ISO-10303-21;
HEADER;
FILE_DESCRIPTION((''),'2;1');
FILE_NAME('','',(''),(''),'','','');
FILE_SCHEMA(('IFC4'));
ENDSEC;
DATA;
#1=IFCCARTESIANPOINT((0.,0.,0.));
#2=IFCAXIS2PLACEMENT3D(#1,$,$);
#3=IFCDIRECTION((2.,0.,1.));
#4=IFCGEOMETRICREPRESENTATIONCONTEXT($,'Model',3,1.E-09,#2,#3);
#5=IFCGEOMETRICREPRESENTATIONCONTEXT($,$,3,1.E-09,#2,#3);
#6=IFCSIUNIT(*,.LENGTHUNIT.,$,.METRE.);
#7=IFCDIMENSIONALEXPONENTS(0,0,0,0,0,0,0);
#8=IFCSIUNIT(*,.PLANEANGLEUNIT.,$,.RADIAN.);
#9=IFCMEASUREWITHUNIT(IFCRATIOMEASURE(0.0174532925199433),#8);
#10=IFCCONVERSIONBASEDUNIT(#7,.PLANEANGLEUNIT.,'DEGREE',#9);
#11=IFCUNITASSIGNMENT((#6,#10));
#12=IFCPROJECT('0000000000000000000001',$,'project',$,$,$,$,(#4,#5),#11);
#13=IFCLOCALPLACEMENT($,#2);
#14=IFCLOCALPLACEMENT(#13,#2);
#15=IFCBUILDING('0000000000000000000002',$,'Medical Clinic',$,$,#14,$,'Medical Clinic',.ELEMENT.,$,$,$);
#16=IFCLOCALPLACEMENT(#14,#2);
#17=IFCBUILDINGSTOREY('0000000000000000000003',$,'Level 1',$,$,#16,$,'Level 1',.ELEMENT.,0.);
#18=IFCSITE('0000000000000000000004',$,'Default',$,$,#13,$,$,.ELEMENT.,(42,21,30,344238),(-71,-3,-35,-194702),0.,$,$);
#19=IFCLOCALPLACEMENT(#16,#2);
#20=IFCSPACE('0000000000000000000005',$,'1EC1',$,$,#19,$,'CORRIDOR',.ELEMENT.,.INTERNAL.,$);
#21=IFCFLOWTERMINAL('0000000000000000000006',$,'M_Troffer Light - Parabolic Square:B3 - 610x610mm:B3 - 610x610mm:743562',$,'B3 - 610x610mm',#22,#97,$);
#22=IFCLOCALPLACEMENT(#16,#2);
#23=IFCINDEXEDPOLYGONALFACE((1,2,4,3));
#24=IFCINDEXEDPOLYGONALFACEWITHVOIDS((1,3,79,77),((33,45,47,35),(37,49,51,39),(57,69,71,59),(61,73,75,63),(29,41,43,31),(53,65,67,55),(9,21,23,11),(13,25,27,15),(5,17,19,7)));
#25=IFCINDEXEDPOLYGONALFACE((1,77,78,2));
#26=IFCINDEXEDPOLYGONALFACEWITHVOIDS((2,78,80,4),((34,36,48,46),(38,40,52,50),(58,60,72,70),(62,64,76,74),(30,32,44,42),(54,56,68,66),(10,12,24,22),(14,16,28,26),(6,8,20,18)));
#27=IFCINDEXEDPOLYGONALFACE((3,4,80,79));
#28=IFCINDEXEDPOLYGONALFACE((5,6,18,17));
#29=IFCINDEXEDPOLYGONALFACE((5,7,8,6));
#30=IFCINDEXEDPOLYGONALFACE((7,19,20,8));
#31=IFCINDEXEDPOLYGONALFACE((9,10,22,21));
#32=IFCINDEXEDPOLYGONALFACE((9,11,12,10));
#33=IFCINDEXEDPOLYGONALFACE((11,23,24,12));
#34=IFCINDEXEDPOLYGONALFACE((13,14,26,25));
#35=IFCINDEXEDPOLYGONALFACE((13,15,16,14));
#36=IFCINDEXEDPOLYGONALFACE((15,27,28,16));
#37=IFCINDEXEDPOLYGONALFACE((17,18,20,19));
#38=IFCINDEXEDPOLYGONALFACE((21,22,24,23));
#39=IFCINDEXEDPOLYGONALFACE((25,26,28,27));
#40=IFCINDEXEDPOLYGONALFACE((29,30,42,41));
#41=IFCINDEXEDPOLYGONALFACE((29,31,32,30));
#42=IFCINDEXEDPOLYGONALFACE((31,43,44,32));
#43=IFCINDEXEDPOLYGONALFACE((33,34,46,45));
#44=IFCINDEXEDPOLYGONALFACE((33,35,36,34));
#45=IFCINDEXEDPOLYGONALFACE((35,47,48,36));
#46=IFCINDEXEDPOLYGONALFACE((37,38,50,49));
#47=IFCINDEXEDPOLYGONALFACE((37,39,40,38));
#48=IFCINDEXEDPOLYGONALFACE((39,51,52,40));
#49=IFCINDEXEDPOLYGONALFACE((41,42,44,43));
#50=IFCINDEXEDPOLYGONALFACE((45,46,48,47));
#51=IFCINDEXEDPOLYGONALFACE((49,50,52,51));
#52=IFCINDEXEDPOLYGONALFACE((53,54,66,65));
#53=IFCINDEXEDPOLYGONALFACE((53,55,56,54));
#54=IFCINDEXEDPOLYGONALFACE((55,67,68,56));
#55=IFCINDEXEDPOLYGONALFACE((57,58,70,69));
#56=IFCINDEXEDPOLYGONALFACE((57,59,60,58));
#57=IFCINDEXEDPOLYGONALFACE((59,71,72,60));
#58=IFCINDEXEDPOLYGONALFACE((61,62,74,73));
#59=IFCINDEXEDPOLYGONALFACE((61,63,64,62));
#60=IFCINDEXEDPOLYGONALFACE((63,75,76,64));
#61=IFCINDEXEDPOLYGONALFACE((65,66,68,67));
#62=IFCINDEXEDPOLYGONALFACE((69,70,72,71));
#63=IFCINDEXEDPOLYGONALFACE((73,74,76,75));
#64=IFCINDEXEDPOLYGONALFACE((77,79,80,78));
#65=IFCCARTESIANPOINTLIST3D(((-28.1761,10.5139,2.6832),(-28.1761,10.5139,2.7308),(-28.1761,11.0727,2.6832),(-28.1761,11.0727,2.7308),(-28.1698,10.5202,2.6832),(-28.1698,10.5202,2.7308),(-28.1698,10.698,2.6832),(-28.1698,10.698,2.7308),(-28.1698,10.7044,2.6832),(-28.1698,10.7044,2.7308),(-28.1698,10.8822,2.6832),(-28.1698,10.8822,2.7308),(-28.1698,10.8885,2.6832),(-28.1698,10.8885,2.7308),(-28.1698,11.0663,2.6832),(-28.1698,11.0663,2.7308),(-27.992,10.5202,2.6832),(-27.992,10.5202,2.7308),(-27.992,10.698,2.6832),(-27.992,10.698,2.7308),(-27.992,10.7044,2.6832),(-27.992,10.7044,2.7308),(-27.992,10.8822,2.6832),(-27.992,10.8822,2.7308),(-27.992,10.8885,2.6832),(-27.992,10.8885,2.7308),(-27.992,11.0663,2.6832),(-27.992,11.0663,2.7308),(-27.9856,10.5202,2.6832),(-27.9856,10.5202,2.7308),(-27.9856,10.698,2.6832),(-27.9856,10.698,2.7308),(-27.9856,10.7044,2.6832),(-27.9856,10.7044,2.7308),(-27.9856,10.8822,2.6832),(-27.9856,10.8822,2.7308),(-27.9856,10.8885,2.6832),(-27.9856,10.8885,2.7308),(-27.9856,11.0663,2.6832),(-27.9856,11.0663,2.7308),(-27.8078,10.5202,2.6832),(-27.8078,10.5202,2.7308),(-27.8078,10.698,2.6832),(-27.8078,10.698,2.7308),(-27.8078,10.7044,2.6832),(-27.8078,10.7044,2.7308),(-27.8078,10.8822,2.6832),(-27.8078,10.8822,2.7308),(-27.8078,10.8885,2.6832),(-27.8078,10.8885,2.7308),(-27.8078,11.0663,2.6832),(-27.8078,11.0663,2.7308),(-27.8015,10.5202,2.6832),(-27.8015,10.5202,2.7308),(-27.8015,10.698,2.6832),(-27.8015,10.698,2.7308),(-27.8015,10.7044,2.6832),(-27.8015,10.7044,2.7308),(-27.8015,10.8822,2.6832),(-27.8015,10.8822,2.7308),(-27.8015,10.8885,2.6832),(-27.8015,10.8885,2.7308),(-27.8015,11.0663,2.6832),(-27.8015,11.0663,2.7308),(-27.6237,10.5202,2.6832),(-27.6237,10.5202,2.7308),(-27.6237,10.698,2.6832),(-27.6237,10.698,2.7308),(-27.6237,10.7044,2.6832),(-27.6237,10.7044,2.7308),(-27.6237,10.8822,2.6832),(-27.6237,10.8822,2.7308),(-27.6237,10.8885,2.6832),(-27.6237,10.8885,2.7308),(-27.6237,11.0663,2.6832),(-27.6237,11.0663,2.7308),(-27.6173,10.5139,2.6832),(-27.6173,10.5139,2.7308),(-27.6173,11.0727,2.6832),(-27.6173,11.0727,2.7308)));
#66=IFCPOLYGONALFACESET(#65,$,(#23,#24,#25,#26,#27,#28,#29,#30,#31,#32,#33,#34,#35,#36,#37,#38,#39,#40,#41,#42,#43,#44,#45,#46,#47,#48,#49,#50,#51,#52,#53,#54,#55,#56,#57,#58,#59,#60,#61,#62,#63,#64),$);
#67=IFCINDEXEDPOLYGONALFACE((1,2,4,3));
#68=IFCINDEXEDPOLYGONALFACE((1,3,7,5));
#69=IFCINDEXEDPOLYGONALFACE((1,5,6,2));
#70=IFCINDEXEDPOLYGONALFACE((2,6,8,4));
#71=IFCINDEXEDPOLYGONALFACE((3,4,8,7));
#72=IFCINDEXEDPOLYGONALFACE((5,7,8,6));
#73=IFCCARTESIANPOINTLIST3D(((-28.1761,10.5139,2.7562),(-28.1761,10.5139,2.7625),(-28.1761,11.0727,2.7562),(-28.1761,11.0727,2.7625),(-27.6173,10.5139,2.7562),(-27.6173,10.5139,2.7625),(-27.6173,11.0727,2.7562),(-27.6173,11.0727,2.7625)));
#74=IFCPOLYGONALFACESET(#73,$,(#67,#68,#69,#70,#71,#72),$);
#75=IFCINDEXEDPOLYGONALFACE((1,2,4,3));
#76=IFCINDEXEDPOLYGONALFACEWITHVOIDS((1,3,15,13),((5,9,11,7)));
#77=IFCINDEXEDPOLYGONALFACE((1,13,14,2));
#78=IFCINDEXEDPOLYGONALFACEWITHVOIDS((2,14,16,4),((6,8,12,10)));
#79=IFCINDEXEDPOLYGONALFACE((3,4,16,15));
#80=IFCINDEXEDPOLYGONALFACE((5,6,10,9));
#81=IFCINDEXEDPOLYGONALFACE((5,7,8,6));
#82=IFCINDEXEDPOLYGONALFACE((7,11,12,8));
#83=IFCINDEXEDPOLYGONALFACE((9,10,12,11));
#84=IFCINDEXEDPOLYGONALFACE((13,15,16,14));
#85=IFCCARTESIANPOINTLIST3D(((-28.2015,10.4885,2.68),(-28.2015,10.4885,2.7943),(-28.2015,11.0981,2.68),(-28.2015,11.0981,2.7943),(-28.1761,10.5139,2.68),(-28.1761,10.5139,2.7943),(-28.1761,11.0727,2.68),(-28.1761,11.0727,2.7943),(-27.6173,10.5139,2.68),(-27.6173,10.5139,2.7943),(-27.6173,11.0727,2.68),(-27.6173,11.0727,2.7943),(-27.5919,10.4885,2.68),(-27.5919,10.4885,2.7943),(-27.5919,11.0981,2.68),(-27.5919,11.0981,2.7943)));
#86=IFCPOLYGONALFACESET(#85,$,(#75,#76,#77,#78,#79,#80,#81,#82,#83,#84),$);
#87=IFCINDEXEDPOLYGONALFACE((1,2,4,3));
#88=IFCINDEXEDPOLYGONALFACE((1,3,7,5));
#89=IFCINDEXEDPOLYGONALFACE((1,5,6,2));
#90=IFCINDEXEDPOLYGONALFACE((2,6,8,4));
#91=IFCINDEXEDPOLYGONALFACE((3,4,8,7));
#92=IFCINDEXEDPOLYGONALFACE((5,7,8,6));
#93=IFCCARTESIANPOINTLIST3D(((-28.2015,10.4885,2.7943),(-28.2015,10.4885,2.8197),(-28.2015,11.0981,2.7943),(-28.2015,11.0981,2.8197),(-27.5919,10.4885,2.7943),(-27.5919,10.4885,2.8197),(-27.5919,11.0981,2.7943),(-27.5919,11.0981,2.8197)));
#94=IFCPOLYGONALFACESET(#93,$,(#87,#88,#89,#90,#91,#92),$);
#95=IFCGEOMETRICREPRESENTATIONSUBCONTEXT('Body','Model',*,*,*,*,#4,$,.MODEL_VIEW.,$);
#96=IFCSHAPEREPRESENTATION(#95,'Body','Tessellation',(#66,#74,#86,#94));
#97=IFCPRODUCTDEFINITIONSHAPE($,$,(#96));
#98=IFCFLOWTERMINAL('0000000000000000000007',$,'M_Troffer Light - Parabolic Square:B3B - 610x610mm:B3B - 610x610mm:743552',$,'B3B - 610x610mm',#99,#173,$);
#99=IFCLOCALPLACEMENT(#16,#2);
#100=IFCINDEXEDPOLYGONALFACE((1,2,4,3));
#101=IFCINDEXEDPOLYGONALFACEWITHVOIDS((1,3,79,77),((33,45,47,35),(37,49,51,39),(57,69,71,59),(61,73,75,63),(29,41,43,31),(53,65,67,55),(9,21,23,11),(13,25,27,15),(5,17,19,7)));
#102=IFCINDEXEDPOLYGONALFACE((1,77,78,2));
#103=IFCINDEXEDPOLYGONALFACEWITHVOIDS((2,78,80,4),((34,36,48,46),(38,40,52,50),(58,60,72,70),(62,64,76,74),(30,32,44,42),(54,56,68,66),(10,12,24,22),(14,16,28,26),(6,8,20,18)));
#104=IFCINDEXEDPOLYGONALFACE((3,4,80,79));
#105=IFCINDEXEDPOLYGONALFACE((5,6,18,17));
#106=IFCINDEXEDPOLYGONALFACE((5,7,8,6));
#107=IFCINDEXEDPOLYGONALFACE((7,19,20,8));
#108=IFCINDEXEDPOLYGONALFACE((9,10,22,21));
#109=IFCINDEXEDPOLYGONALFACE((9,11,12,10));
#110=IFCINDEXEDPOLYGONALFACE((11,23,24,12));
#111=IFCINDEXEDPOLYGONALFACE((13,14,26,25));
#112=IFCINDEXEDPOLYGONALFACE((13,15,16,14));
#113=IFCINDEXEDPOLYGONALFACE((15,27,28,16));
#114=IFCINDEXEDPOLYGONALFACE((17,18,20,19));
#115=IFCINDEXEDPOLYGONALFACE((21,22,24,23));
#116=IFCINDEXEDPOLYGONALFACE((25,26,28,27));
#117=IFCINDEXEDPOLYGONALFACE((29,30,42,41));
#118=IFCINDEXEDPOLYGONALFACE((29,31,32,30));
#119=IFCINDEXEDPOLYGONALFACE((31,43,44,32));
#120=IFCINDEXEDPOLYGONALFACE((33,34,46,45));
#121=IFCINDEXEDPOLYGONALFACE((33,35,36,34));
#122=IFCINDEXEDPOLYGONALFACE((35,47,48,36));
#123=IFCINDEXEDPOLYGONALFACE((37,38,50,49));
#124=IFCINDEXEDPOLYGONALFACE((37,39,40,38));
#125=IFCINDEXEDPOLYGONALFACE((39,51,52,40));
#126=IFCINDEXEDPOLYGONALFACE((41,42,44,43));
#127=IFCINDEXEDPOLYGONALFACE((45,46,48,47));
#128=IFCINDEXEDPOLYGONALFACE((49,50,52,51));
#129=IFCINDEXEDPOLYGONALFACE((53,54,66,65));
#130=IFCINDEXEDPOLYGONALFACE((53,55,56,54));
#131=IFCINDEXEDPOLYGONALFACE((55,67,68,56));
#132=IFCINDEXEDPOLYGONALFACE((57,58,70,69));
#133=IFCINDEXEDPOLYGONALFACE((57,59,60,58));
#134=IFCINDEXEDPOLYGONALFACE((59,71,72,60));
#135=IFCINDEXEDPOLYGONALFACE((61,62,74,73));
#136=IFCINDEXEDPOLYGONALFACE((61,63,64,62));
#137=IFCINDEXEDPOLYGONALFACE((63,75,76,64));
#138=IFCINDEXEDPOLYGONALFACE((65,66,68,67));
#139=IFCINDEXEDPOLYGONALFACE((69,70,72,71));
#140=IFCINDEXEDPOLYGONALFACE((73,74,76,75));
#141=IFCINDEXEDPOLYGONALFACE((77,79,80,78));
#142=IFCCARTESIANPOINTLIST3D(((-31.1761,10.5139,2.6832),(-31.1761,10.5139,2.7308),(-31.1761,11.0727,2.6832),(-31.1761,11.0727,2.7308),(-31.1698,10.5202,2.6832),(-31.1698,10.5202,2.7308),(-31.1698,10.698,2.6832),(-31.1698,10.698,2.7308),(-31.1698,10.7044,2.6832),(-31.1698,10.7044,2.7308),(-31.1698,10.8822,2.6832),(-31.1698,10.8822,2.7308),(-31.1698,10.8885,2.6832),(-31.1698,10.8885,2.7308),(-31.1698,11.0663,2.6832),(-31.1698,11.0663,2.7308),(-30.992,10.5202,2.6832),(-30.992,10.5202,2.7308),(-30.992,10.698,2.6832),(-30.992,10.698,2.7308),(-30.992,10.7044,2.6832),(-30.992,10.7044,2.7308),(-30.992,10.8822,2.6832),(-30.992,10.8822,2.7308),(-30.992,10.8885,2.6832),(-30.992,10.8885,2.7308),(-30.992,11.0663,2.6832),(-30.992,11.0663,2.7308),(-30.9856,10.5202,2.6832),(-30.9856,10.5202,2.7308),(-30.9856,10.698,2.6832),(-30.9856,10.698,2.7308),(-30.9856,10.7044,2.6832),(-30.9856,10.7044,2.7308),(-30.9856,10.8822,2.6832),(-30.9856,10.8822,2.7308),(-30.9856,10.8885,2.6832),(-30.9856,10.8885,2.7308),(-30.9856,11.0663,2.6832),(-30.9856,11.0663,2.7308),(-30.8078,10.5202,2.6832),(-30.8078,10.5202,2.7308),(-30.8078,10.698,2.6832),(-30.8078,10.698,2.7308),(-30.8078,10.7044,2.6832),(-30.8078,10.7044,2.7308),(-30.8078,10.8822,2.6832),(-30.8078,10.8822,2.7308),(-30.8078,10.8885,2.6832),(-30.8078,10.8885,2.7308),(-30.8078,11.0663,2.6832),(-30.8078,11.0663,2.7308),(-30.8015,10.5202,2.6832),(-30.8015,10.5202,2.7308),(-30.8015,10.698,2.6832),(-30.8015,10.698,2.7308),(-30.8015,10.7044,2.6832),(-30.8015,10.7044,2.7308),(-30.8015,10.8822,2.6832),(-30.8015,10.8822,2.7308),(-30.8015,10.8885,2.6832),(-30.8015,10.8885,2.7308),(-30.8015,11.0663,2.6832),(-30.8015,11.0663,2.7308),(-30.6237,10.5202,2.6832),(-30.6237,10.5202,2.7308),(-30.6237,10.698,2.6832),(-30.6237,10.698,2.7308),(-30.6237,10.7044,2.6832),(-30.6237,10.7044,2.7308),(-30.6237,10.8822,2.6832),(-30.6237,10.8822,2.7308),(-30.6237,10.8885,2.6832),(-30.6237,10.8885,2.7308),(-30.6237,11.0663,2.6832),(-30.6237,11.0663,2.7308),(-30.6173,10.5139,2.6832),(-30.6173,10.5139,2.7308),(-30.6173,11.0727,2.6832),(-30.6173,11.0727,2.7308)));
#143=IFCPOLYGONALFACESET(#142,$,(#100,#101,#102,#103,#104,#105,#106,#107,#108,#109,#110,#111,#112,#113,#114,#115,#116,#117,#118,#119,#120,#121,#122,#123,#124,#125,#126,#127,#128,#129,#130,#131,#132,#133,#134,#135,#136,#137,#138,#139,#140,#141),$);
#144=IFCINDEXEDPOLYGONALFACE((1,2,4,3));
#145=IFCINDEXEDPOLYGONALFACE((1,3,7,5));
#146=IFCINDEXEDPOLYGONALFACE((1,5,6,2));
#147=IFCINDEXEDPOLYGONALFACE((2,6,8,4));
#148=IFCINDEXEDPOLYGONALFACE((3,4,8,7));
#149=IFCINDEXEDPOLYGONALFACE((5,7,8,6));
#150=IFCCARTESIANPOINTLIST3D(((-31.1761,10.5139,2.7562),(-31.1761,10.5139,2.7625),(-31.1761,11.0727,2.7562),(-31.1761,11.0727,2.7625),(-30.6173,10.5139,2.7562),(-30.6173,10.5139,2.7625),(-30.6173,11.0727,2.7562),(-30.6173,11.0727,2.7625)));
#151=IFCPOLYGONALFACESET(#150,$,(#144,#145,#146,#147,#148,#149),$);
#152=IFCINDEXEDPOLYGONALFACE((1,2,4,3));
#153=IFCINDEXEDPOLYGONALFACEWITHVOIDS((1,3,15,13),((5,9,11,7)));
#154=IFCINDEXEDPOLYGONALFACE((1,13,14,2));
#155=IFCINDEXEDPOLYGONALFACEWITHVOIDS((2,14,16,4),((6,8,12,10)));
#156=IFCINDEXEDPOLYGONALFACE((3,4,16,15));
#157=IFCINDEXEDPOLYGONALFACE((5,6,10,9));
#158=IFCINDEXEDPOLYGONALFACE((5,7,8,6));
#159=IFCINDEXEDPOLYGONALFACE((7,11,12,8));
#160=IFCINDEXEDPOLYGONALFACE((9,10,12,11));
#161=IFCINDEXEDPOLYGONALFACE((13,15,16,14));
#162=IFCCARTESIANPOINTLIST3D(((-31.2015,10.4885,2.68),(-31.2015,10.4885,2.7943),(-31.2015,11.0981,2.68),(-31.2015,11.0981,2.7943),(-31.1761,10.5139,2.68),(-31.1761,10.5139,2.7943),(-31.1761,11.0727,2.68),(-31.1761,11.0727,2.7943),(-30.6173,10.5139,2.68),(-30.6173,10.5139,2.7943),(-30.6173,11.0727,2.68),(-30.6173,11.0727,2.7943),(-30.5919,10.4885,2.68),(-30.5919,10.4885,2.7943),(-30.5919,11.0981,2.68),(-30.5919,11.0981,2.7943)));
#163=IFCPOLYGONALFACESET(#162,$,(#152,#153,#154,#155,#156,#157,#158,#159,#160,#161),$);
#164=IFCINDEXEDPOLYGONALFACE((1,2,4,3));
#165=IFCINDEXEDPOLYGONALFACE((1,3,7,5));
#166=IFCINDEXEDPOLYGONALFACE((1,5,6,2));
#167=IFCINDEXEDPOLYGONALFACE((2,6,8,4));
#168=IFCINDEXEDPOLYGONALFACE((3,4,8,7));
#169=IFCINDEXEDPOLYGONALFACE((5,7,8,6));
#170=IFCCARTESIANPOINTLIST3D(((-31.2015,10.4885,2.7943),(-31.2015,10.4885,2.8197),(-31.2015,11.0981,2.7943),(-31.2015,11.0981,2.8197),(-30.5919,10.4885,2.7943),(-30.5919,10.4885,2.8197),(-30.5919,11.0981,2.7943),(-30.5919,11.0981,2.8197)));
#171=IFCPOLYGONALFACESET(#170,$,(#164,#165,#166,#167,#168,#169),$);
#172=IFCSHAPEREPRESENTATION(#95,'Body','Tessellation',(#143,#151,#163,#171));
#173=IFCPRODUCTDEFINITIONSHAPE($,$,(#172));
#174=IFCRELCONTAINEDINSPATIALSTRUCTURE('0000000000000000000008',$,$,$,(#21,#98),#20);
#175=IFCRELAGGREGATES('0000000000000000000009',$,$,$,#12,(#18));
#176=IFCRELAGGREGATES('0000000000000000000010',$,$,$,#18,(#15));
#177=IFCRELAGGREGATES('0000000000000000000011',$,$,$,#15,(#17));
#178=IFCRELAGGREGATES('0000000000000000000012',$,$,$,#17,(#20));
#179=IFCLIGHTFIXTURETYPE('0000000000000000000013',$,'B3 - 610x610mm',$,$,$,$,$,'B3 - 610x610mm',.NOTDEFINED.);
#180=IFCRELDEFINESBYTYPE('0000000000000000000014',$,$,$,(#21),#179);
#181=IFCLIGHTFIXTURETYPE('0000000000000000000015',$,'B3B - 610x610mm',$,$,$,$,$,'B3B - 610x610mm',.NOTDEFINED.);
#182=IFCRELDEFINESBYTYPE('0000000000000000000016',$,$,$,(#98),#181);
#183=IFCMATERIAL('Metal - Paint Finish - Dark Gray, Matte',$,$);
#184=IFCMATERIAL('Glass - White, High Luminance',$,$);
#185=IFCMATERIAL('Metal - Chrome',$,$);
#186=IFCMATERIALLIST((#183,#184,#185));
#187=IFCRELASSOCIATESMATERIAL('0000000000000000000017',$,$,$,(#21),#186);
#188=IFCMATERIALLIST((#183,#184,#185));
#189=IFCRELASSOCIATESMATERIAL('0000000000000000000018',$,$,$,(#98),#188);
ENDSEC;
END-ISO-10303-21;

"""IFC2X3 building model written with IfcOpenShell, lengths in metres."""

from ifc_helpers import new_model, entity, si_unit, converted_unit, direction, frame, origin, origin_2d_with_axis, place, context, subcontext, project, spatial, polyline, rectangle, outline, extrude, source, transform, mapped, material, material_list, type_object, type_shapes, element, save


model = new_model("IFC2X3")

# Units and contexts
model_context = context("Model", 3, precision=1e-09, world=origin(), true_north=direction((2.0, 0.0, 1.0)))
context_of_model = context(None, 3, precision=1e-09, world=origin(), true_north=direction((2.0, 0.0, 1.0)))
body_context = subcontext(model_context, "Body", "Model", "MODEL_VIEW")
ifc_project = project(units=[si_unit("LENGTHUNIT", "METRE"), converted_unit("PLANEANGLEUNIT", "DEGREE", entity("IfcRatioMeasure", 0.0174532925199433), si_unit("PLANEANGLEUNIT", "RADIAN"), dimensions=[0, 0, 0, 0, 0, 0, 0])], contexts=[model_context, context_of_model])

# Site, building, storey
site_placement = place(None, origin())
site = spatial("IfcSite", under=ifc_project, at=site_placement, Name="Default", CompositionType="ELEMENT", RefLatitude=(42, 21, 30, 344238), RefLongitude=(-71, -3, -35, -194702), RefElevation=0.0)
building_placement = place(site_placement, origin())
building = spatial("IfcBuilding", under=site, at=building_placement, Name="Medical Clinic", LongName="Medical Clinic", CompositionType="ELEMENT")
storey_placement = place(building_placement, origin())
storey = spatial("IfcBuildingStorey", under=building, at=storey_placement, Name="Level 1", LongName="Level 1", CompositionType="ELEMENT", Elevation=0.0)

# Shared definitions
ifc_material_1 = material(Name="Metal - Paint Finish - Dark Gray, Matte")
ifc_material_2 = material(Name="Glass - White, High Luminance")
ifc_material_3 = material(Name="Metal - Chrome")
light_fixture_type_1 = type_object("IfcLightFixtureType", Name="B3 - 610x610mm", ElementType="B3 - 610x610mm", PredefinedType="NOTDEFINED")
shared_shape_1 = source(origin(), body_context, "Body", "SweptSolid", [
    extrude(outline(polyline([(-0.2794, -0.2794), (0.2794, -0.2794), (0.2794, 0.2794), (-0.2794, 0.2794), (-0.2794, -0.2794)]), holes=[polyline([(-0.0952, 0.0953), (-0.273, 0.0953), (-0.273, 0.2731), (-0.0952, 0.2731), (-0.0952, 0.0953)]), polyline([(0.2731, 0.0953), (0.0953, 0.0953), (0.0953, 0.2731), (0.2731, 0.2731), (0.2731, 0.0953)]), polyline([(-0.0889, 0.2731), (0.0889, 0.2731), (0.0889, 0.0953), (-0.0889, 0.0953), (-0.0889, 0.2731)]), polyline([(0.2731, -0.273), (0.0953, -0.273), (0.0953, -0.0952), (0.2731, -0.0952), (0.2731, -0.273)]), polyline([(0.0889, -0.273), (-0.0889, -0.273), (-0.0889, -0.0952), (0.0889, -0.0952), (0.0889, -0.273)]), polyline([(-0.0952, -0.273), (-0.273, -0.273), (-0.273, -0.0952), (-0.0952, -0.0952), (-0.0952, -0.273)]), polyline([(-0.0952, -0.0889), (-0.273, -0.0889), (-0.273, 0.0889), (-0.0952, 0.0889), (-0.0952, -0.0889)]), polyline([(0.0889, -0.0889), (-0.0889, -0.0889), (-0.0889, 0.0889), (0.0889, 0.0889), (0.0889, -0.0889)]), polyline([(0.2731, -0.0889), (0.0953, -0.0889), (0.0953, 0.0889), (0.2731, 0.0889), (0.2731, -0.0889)])]), frame((0.0, -0.3048, -0.0508), z_axis=(0.0, 0.0, 1.0), x_axis=(-1.0, 0.0, 0.0)), (0.0, 0.0, 1.0), 0.0476),
    extrude(rectangle(XDim=0.5588, YDim=0.5588, at=origin_2d_with_axis()), frame((0.0, -0.3048, -0.0825), z_axis=(0.0, 0.0, 1.0), x_axis=(-1.0, 0.0, 0.0)), (0.0, 0.0, 1.0), 0.0064),
    extrude(outline(polyline([(-0.3048, -0.3048), (0.3048, -0.3048), (0.3048, 0.3048), (-0.3048, 0.3048), (-0.3048, -0.3048)]), holes=[polyline([(0.2794, 0.2794), (0.2794, -0.2794), (-0.2794, -0.2794), (-0.2794, 0.2794), (0.2794, 0.2794)])]), frame((0.0, -0.3048, -0.1143)), (0.0, 0.0, 1.0), 0.1143),
    extrude(rectangle(XDim=0.6096, YDim=0.6096, at=origin_2d_with_axis()), frame((0.0, -0.3048, -0.1397), z_axis=(0.0, 0.0, 1.0), x_axis=(-1.0, 0.0, 0.0)), (0.0, 0.0, 1.0), 0.0254),
])
type_shapes(light_fixture_type_1, [shared_shape_1])

# Shared definitions
space_1_placement = place(storey_placement, origin())
space_1 = spatial("IfcSpace", under=storey, at=space_1_placement, Name="1EC1", LongName="CORRIDOR", CompositionType="ELEMENT", InteriorOrExteriorSpace="INTERNAL")

# Flow terminals
ifc_material_list_1 = material_list([ifc_material_1, ifc_material_2, ifc_material_3])
flow_terminal_1_placement = place(space_1_placement, frame((-27.8967, 10.4885, 2.68), z_axis=(0.0, 0.0, -1.0), x_axis=(1.0, 0.0, 0.0)))
element("IfcFlowTerminal", 1, at=flow_terminal_1_placement, inside=space_1, type_object=light_fixture_type_1, material=ifc_material_list_1, Name="M_Troffer Light - Parabolic Square:B3 - 610x610mm:B3 - 610x610mm:743562", ObjectType="B3 - 610x610mm", context=body_context, shape_type="MappedRepresentation", body=[
    mapped(shared_shape_1, transform((0.0, 0.0, 0.0), scale=1.0)),
])
ifc_material_list_2 = material_list([ifc_material_1, ifc_material_2, ifc_material_3])
light_fixture_type_2 = type_object("IfcLightFixtureType", Name="B3B - 610x610mm", ElementType="B3B - 610x610mm", PredefinedType="NOTDEFINED")
shared_shape_2 = source(origin(), body_context, "Body", "SweptSolid", [
    extrude(outline(polyline([(-0.2794, -0.2794), (0.2794, -0.2794), (0.2794, 0.2794), (-0.2794, 0.2794), (-0.2794, -0.2794)]), holes=[polyline([(-0.0952, 0.0953), (-0.273, 0.0953), (-0.273, 0.2731), (-0.0952, 0.2731), (-0.0952, 0.0953)]), polyline([(0.2731, 0.0953), (0.0953, 0.0953), (0.0953, 0.2731), (0.2731, 0.2731), (0.2731, 0.0953)]), polyline([(-0.0889, 0.2731), (0.0889, 0.2731), (0.0889, 0.0953), (-0.0889, 0.0953), (-0.0889, 0.2731)]), polyline([(0.2731, -0.273), (0.0953, -0.273), (0.0953, -0.0952), (0.2731, -0.0952), (0.2731, -0.273)]), polyline([(0.0889, -0.273), (-0.0889, -0.273), (-0.0889, -0.0952), (0.0889, -0.0952), (0.0889, -0.273)]), polyline([(-0.0952, -0.273), (-0.273, -0.273), (-0.273, -0.0952), (-0.0952, -0.0952), (-0.0952, -0.273)]), polyline([(-0.0952, -0.0889), (-0.273, -0.0889), (-0.273, 0.0889), (-0.0952, 0.0889), (-0.0952, -0.0889)]), polyline([(0.0889, -0.0889), (-0.0889, -0.0889), (-0.0889, 0.0889), (0.0889, 0.0889), (0.0889, -0.0889)]), polyline([(0.2731, -0.0889), (0.0953, -0.0889), (0.0953, 0.0889), (0.2731, 0.0889), (0.2731, -0.0889)])]), frame((0.0, -0.3048, -0.0508), z_axis=(0.0, 0.0, 1.0), x_axis=(-1.0, 0.0, 0.0)), (0.0, 0.0, 1.0), 0.0476),
    extrude(rectangle(XDim=0.5588, YDim=0.5588, at=origin_2d_with_axis()), frame((0.0, -0.3048, -0.0825), z_axis=(0.0, 0.0, 1.0), x_axis=(-1.0, 0.0, 0.0)), (0.0, 0.0, 1.0), 0.0064),
    extrude(outline(polyline([(-0.3048, -0.3048), (0.3048, -0.3048), (0.3048, 0.3048), (-0.3048, 0.3048), (-0.3048, -0.3048)]), holes=[polyline([(0.2794, 0.2794), (0.2794, -0.2794), (-0.2794, -0.2794), (-0.2794, 0.2794), (0.2794, 0.2794)])]), frame((0.0, -0.3048, -0.1143)), (0.0, 0.0, 1.0), 0.1143),
    extrude(rectangle(XDim=0.6096, YDim=0.6096, at=origin_2d_with_axis()), frame((0.0, -0.3048, -0.1397), z_axis=(0.0, 0.0, 1.0), x_axis=(-1.0, 0.0, 0.0)), (0.0, 0.0, 1.0), 0.0254),
])
type_shapes(light_fixture_type_2, [shared_shape_2])
flow_terminal_2_placement = place(space_1_placement, frame((-30.8967, 10.4885, 2.68), z_axis=(0.0, 0.0, -1.0), x_axis=(1.0, 0.0, 0.0)))
element("IfcFlowTerminal", 2, at=flow_terminal_2_placement, inside=space_1, type_object=light_fixture_type_2, material=ifc_material_list_2, Name="M_Troffer Light - Parabolic Square:B3B - 610x610mm:B3B - 610x610mm:743552", ObjectType="B3B - 610x610mm", context=body_context, shape_type="MappedRepresentation", body=[
    mapped(shared_shape_2, transform((0.0, 0.0, 0.0), scale=1.0)),
])

save(model, "model.ifc")
